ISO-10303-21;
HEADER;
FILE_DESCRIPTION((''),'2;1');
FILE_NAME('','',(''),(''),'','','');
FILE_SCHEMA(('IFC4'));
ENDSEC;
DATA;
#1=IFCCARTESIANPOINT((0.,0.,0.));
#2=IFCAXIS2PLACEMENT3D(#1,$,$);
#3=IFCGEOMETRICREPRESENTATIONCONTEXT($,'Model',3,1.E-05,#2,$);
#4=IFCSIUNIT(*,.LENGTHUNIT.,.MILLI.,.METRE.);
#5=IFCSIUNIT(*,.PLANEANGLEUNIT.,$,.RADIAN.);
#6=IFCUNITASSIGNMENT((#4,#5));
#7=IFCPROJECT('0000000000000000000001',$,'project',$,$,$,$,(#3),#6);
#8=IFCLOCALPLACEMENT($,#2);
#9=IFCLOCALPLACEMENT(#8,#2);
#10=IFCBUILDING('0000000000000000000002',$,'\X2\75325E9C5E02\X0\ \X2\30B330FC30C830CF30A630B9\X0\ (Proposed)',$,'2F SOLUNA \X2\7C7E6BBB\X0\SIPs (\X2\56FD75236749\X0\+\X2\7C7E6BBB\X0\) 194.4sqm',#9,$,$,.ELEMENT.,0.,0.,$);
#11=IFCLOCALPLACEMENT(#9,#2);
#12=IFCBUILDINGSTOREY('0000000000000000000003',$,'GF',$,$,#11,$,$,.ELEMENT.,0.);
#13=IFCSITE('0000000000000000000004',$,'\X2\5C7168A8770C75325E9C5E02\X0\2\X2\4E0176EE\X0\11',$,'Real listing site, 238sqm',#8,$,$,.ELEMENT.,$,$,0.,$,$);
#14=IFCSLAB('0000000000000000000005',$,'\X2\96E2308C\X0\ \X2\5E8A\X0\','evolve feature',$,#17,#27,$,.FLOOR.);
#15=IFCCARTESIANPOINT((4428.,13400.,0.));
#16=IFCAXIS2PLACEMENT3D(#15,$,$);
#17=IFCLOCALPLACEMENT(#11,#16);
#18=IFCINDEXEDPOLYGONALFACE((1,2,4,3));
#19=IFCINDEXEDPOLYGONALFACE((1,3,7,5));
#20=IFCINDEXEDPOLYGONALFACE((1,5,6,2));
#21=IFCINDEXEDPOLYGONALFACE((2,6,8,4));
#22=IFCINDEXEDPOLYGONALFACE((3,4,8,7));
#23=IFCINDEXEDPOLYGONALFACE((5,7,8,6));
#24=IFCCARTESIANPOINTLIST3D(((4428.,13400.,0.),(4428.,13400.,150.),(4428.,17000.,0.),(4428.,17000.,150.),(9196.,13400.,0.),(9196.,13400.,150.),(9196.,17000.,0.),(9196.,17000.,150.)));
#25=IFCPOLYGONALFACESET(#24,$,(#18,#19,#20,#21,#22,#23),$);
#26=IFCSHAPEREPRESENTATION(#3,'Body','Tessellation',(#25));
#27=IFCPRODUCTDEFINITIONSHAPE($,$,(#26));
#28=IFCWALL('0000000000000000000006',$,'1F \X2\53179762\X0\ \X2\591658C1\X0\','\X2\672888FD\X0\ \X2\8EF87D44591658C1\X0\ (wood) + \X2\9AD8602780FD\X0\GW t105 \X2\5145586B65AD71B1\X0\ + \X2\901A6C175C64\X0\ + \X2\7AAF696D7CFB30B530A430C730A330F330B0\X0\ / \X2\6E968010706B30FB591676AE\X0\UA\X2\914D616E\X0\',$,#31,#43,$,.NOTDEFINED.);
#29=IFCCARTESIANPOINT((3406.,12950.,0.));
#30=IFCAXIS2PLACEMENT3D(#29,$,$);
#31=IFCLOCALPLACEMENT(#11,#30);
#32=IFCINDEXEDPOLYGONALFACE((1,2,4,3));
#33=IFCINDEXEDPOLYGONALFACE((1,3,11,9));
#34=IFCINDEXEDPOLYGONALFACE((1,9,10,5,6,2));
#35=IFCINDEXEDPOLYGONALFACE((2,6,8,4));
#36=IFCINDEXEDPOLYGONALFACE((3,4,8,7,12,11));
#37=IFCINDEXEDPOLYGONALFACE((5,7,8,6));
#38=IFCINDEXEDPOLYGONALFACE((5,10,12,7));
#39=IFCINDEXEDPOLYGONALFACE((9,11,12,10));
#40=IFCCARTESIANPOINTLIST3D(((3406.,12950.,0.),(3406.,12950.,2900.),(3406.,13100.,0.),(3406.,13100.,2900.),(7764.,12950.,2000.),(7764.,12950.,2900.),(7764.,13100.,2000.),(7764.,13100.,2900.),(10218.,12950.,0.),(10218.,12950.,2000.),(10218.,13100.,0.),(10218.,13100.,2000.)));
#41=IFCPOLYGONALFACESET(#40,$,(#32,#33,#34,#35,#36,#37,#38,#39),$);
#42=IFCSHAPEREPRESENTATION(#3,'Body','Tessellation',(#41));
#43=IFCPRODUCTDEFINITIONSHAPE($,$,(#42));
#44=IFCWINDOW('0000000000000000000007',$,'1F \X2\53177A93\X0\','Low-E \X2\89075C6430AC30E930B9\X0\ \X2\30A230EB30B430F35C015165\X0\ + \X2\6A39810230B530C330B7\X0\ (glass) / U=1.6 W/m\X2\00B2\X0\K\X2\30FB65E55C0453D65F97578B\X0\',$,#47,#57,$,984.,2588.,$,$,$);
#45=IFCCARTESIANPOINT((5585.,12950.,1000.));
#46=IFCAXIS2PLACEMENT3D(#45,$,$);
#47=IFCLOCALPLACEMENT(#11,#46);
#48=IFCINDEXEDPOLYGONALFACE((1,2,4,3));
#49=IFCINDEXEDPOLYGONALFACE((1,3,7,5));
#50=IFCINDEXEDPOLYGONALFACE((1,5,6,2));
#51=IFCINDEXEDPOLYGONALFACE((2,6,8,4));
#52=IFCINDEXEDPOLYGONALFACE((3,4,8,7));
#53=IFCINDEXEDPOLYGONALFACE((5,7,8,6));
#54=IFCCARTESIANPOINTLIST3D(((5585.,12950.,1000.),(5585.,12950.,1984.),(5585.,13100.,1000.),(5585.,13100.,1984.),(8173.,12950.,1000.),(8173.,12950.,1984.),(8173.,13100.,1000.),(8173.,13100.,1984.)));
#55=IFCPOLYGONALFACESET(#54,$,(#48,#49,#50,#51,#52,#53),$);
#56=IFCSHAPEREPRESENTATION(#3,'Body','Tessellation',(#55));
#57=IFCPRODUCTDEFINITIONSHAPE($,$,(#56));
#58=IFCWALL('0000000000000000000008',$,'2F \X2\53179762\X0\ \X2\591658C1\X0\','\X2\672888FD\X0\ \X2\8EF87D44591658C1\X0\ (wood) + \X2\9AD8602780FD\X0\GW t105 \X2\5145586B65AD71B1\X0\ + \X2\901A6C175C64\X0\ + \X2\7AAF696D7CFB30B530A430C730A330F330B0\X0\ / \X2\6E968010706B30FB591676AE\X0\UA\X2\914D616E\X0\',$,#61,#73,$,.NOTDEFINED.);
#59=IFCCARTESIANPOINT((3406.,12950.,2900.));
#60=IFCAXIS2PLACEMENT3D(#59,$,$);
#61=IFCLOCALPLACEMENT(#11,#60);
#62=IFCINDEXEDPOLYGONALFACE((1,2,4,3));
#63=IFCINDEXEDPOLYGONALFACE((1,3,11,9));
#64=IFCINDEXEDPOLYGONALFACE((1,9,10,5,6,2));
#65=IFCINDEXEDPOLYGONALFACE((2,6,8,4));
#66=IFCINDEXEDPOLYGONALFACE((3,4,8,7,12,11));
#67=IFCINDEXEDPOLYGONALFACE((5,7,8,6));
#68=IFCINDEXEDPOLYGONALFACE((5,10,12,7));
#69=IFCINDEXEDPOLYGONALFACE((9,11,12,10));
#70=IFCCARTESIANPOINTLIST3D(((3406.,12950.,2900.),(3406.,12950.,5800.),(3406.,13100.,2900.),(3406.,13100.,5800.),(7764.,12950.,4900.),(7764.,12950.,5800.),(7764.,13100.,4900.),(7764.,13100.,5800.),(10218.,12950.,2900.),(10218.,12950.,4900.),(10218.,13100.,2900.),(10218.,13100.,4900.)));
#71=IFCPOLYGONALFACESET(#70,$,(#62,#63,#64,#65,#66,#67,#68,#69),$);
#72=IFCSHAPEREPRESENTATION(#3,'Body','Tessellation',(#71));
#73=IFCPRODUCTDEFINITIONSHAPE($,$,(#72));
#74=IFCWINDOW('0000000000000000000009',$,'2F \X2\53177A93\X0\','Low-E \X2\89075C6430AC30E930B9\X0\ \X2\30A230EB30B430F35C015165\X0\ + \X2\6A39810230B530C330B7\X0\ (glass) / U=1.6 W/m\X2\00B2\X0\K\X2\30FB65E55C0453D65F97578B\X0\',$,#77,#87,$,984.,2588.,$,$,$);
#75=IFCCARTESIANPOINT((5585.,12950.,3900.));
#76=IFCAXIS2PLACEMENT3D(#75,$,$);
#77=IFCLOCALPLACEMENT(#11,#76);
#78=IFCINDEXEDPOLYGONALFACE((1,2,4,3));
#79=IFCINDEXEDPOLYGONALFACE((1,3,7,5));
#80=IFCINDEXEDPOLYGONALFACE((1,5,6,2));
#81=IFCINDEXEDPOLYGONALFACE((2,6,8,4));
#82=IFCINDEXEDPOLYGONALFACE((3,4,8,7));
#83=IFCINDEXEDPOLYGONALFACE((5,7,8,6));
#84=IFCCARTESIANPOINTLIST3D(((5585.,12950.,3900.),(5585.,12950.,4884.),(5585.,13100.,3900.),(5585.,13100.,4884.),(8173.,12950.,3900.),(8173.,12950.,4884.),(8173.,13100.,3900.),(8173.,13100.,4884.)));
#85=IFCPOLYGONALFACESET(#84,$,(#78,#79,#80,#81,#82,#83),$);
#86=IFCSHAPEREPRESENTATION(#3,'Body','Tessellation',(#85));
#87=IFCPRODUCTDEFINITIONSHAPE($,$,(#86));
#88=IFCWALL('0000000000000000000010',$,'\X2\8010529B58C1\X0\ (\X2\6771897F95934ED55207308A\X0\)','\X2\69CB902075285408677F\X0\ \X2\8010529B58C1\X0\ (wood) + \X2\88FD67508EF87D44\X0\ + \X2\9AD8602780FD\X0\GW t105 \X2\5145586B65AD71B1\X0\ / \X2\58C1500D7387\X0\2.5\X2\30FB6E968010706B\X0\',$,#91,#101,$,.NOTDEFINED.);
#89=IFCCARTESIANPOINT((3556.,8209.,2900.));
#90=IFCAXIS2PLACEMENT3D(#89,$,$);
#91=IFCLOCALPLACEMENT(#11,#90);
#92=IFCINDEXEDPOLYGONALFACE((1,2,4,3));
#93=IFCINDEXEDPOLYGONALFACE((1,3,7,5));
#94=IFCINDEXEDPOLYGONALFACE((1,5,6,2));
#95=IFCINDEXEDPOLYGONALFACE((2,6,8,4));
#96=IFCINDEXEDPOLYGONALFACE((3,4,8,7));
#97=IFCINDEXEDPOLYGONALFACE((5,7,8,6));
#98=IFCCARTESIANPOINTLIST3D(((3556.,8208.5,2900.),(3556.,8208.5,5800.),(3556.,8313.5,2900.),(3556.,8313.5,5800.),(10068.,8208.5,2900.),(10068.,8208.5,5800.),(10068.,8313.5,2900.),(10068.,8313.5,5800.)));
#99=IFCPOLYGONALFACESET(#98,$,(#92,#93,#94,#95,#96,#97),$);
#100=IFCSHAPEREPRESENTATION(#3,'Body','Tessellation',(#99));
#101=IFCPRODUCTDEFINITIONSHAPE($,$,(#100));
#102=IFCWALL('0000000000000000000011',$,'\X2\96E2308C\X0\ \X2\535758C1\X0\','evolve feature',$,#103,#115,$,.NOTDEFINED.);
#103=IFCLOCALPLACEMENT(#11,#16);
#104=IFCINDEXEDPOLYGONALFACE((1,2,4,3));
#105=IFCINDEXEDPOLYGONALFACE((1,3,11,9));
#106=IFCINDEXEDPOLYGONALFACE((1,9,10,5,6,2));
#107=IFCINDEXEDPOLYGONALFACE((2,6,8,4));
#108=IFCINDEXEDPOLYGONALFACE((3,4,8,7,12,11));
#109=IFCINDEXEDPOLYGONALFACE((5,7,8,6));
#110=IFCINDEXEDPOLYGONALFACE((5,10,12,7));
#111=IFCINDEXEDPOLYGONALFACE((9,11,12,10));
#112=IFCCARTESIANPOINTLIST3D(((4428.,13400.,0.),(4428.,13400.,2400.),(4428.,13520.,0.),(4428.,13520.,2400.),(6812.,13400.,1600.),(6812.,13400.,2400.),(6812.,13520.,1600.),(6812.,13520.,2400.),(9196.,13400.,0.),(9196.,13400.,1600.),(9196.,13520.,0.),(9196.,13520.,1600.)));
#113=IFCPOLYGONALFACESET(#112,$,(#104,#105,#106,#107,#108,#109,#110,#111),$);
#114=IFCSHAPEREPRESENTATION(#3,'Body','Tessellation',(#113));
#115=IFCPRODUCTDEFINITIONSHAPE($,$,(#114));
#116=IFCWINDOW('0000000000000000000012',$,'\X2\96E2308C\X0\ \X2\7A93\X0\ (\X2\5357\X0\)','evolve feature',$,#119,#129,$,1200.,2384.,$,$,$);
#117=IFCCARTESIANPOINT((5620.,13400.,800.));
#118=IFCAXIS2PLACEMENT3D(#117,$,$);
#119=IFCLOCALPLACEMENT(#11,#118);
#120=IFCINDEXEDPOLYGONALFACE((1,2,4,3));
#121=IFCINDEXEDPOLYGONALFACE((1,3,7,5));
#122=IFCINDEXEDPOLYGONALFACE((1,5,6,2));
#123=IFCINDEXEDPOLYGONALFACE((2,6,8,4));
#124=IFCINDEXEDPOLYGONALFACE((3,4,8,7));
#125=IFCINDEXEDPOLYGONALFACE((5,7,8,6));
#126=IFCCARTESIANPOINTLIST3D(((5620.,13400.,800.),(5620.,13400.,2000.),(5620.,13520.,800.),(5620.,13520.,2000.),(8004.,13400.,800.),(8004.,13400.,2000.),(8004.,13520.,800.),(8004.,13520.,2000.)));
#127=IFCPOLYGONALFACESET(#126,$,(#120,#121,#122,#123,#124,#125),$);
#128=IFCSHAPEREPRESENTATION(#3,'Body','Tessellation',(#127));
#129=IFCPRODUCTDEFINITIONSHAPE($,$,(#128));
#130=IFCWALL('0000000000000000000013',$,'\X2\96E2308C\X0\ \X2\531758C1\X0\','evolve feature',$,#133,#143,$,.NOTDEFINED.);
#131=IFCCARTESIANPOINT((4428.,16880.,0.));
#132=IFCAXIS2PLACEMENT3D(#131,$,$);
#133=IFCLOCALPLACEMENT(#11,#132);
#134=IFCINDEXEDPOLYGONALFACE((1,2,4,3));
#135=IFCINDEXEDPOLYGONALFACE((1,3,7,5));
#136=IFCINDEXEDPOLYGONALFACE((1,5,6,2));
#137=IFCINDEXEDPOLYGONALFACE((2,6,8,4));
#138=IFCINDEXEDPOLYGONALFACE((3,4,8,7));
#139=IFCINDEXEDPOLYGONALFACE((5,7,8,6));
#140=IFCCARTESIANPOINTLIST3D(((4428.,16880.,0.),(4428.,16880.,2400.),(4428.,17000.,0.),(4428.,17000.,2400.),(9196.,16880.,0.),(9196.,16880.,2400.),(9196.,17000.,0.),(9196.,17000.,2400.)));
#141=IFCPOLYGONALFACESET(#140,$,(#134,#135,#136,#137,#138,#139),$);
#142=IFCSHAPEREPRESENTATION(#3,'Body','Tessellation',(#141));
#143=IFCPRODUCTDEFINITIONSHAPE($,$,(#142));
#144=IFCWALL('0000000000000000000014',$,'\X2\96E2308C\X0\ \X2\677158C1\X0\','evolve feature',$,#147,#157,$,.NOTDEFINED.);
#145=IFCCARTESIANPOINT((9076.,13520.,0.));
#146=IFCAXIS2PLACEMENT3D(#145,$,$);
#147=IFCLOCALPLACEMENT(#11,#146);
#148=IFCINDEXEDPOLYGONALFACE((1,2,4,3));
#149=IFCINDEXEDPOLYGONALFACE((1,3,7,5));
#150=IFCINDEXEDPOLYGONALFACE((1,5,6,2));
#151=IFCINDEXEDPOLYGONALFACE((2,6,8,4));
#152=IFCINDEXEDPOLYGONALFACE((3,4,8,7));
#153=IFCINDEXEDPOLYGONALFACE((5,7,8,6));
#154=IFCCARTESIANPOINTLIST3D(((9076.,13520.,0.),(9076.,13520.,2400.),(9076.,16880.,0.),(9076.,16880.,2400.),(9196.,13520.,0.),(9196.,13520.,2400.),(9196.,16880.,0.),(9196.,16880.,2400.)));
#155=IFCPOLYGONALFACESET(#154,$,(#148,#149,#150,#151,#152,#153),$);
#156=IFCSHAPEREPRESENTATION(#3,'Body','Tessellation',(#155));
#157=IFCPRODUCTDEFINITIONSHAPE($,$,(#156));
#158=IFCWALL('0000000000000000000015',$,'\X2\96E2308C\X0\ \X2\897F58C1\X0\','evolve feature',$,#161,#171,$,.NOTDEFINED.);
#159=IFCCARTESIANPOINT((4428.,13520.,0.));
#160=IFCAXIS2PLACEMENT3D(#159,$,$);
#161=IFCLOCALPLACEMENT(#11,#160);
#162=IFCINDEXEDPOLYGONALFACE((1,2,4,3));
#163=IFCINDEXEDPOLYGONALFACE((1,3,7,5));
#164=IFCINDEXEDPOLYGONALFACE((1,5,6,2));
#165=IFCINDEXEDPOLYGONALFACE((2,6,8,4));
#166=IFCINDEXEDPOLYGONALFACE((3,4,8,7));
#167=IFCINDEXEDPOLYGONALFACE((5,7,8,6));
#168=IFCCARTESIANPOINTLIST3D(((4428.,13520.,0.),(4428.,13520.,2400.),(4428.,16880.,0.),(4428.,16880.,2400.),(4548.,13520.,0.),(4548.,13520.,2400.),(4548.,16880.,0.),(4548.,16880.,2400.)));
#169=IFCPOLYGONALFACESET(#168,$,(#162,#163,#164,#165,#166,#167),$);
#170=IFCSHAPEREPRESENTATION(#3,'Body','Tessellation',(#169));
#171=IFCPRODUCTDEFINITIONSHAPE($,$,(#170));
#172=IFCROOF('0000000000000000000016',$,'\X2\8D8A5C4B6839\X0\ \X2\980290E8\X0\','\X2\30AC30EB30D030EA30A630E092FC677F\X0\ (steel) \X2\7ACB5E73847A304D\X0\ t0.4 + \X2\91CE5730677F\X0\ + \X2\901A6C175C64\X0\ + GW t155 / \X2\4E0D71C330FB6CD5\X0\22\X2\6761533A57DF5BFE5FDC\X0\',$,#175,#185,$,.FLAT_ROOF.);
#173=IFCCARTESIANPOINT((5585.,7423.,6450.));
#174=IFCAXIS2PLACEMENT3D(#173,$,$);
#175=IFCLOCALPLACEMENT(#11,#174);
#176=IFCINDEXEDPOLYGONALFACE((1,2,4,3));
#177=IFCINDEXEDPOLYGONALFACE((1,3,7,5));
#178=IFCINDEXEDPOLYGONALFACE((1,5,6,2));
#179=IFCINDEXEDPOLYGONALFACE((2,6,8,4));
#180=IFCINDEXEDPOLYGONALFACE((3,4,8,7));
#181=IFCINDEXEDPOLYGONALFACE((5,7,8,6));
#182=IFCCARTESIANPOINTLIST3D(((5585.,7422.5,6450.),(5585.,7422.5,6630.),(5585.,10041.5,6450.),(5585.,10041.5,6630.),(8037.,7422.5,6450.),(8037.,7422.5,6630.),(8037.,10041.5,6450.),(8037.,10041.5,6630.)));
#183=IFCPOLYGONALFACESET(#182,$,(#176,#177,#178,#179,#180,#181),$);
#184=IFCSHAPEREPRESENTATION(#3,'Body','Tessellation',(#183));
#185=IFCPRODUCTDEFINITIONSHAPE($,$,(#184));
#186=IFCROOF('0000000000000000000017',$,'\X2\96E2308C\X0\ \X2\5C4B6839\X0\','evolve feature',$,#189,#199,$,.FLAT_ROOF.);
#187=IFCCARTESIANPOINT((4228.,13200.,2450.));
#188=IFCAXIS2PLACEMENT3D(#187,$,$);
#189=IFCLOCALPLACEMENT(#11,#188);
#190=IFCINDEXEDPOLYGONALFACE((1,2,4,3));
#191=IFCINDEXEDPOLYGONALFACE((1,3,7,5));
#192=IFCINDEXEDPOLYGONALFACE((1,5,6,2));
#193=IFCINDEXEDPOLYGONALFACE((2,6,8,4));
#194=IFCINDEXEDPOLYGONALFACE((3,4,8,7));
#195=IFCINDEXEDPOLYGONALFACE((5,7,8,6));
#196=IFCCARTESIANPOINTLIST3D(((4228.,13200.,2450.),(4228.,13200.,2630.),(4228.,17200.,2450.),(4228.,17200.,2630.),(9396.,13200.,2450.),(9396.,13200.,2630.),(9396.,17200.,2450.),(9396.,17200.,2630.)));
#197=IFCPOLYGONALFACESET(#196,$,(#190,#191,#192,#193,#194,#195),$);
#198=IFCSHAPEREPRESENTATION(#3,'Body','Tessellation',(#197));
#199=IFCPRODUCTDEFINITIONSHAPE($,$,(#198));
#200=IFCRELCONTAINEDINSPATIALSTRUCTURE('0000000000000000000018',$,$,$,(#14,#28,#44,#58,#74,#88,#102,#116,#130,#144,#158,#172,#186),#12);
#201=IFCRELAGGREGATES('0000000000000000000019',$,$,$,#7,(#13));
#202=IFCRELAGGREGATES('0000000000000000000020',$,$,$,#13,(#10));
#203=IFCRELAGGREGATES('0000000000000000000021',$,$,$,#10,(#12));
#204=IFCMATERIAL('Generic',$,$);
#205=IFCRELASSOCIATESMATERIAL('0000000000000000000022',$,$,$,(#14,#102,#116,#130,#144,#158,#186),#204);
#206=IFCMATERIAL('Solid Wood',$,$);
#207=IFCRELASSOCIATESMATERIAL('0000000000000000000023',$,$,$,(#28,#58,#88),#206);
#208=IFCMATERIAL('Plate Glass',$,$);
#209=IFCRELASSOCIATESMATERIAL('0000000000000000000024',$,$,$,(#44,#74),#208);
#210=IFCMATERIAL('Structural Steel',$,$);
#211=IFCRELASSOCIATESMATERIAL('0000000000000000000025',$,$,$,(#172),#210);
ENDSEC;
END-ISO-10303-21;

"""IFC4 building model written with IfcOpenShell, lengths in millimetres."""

from ifc_helpers import new_model, si_unit, frame, frame_2d, origin, place, context, project, spatial, rectangle, extrude, material, element, fill, save


model = new_model("IFC4")

# Units and contexts
model_context = context("Model", 3, precision=1e-05, world=origin())
ifc_project = project(units=[si_unit("LENGTHUNIT", "METRE", prefix="MILLI"), si_unit("PLANEANGLEUNIT", "RADIAN")], contexts=[model_context])

# Site, building, storey
site_placement = place(None, origin())
site = spatial("IfcSite", under=ifc_project, at=site_placement, Name="山梨県甲府市2丁目11", ObjectType="Real listing site, 238sqm", CompositionType="ELEMENT", RefElevation=0.0)
building_placement = place(site_placement, origin())
building = spatial("IfcBuilding", under=site, at=building_placement, Name="甲府市 コートハウス (Proposed)", ObjectType="2F SOLUNA 籾殻SIPs (国産杉+籾殻) 194.4sqm", CompositionType="ELEMENT", ElevationOfRefHeight=0.0, ElevationOfTerrain=0.0)
storey_placement = place(building_placement, origin())
storey = spatial("IfcBuildingStorey", under=building, at=storey_placement, Name="GF", CompositionType="ELEMENT", Elevation=0.0)

# Slab
ifc_material_1 = material(Name="Generic")
slab_placement = place(storey_placement, frame((4428.0, 13400.0, 0.0)))
element("IfcSlab", 1, at=slab_placement, inside=storey, material=ifc_material_1, Name="離れ 床", Description="evolve feature", PredefinedType="FLOOR", context=model_context, shape_type="SweptSolid", body=[
    extrude(rectangle(XDim=4768.0, YDim=3600.0, at=frame_2d((2384.0, 1800.0))), frame((4428.0, 13400.0, 0.0)), (0.0, 0.0, 1.0), 150.0),
])

# Wall, opening, window
ifc_material_2 = material(Name="Solid Wood")
wall_1_placement = place(storey_placement, frame((3406.0, 12950.0, 0.0)))
wall_1 = element("IfcWall", 2, at=wall_1_placement, inside=storey, material=ifc_material_2, Name="1F 北面 外壁", Description="木製 軸組外壁 (wood) + 高性能GW t105 充填断熱 + 通気層 + 窯業系サイディング / 準耐火・外皮UA配慮", PredefinedType="NOTDEFINED", context=model_context, shape_type="SweptSolid", body=[
    extrude(rectangle(XDim=6812.0, YDim=150.0, at=frame_2d((3406.0, 75.0))), frame((3406.0, 12950.0, 0.0)), (0.0, 0.0, 1.0), 2900.0),
])
opening_1_placement = place(storey_placement, frame((5585.0, 12950.0, 1000.0)))
opening_1 = element("IfcOpeningElement", 3, at=opening_1_placement, cuts=wall_1, PredefinedType="NOTDEFINED", context=model_context, shape_type="SweptSolid", body=[
    extrude(rectangle(XDim=2588.0, YDim=150.0, at=frame_2d((1294.0, 75.0))), frame((5585.0, 12950.0, 1000.0)), (0.0, 0.0, 1.0), 984.0),
])
ifc_material_3 = material(Name="Plate Glass")
window_1_placement = place(storey_placement, frame((5585.0, 12950.0, 1000.0)))
window_1 = element("IfcWindow", 4, at=window_1_placement, inside=storey, material=ifc_material_3, Name="1F 北窓", Description="Low-E 複層ガラス アルゴン封入 + 樹脂サッシ (glass) / U=1.6 W/m²K・日射取得型", OverallHeight=984.0, OverallWidth=2588.0, context=model_context, shape_type="SweptSolid", body=[
    extrude(rectangle(XDim=2588.0, YDim=150.0, at=frame_2d((1294.0, 75.0))), frame((5585.0, 12950.0, 1000.0)), (0.0, 0.0, 1.0), 984.0),
])
fill(opening_1, window_1)

# Wall, opening, window
wall_2_placement = place(storey_placement, frame((3406.0, 12950.0, 2900.0)))
wall_2 = element("IfcWall", 5, at=wall_2_placement, inside=storey, material=ifc_material_2, Name="2F 北面 外壁", Description="木製 軸組外壁 (wood) + 高性能GW t105 充填断熱 + 通気層 + 窯業系サイディング / 準耐火・外皮UA配慮", PredefinedType="NOTDEFINED", context=model_context, shape_type="SweptSolid", body=[
    extrude(rectangle(XDim=6812.0, YDim=150.0, at=frame_2d((3406.0, 75.0))), frame((3406.0, 12950.0, 2900.0)), (0.0, 0.0, 1.0), 2900.0),
])
opening_2_placement = place(storey_placement, frame((5585.0, 12950.0, 3900.0)))
opening_2 = element("IfcOpeningElement", 6, at=opening_2_placement, cuts=wall_2, PredefinedType="NOTDEFINED", context=model_context, shape_type="SweptSolid", body=[
    extrude(rectangle(XDim=2588.0, YDim=150.0, at=frame_2d((1294.0, 75.0))), frame((5585.0, 12950.0, 3900.0)), (0.0, 0.0, 1.0), 984.0),
])
window_2_placement = place(storey_placement, frame((5585.0, 12950.0, 3900.0)))
window_2 = element("IfcWindow", 7, at=window_2_placement, inside=storey, material=ifc_material_3, Name="2F 北窓", Description="Low-E 複層ガラス アルゴン封入 + 樹脂サッシ (glass) / U=1.6 W/m²K・日射取得型", OverallHeight=984.0, OverallWidth=2588.0, context=model_context, shape_type="SweptSolid", body=[
    extrude(rectangle(XDim=2588.0, YDim=150.0, at=frame_2d((1294.0, 75.0))), frame((5585.0, 12950.0, 3900.0)), (0.0, 0.0, 1.0), 984.0),
])
fill(opening_2, window_2)

# Wall
wall_3_placement = place(storey_placement, frame((3556.0, 8209.0, 2900.0)))
element("IfcWall", 8, at=wall_3_placement, inside=storey, material=ifc_material_2, Name="耐力壁 (東西間仕切り)", Description="構造用合板 耐力壁 (wood) + 製材軸組 + 高性能GW t105 充填断熱 / 壁倍率2.5・準耐火", PredefinedType="NOTDEFINED", context=model_context, shape_type="SweptSolid", body=[
    extrude(rectangle(XDim=6512.0, YDim=105.0, at=frame_2d((3256.0, 52.0))), frame((3556.0, 8209.0, 2900.0)), (0.0, 0.0, 1.0), 2900.0),
])

# Wall, opening, window
wall_4_placement = place(storey_placement, frame((4428.0, 13400.0, 0.0)))
wall_4 = element("IfcWall", 9, at=wall_4_placement, inside=storey, material=ifc_material_1, Name="離れ 南壁", Description="evolve feature", PredefinedType="NOTDEFINED", context=model_context, shape_type="SweptSolid", body=[
    extrude(rectangle(XDim=4768.0, YDim=120.0, at=frame_2d((2384.0, 60.0))), frame((4428.0, 13400.0, 0.0)), (0.0, 0.0, 1.0), 2400.0),
])
opening_3_placement = place(storey_placement, frame((5620.0, 13400.0, 800.0)))
opening_3 = element("IfcOpeningElement", 10, at=opening_3_placement, cuts=wall_4, PredefinedType="NOTDEFINED", context=model_context, shape_type="SweptSolid", body=[
    extrude(rectangle(XDim=2384.0, YDim=120.0, at=frame_2d((1192.0, 60.0))), frame((5620.0, 13400.0, 800.0)), (0.0, 0.0, 1.0), 1200.0),
])
window_3_placement = place(storey_placement, frame((5620.0, 13400.0, 800.0)))
window_3 = element("IfcWindow", 11, at=window_3_placement, inside=storey, material=ifc_material_1, Name="離れ 窓 (南)", Description="evolve feature", OverallHeight=1200.0, OverallWidth=2384.0, context=model_context, shape_type="SweptSolid", body=[
    extrude(rectangle(XDim=2384.0, YDim=120.0, at=frame_2d((1192.0, 60.0))), frame((5620.0, 13400.0, 800.0)), (0.0, 0.0, 1.0), 1200.0),
])
fill(opening_3, window_3)

# Walls
wall_5_placement = place(storey_placement, frame((4428.0, 16880.0, 0.0)))
element("IfcWall", 12, at=wall_5_placement, inside=storey, material=ifc_material_1, Name="離れ 北壁", Description="evolve feature", PredefinedType="NOTDEFINED", context=model_context, shape_type="SweptSolid", body=[
    extrude(rectangle(XDim=4768.0, YDim=120.0, at=frame_2d((2384.0, 60.0))), frame((4428.0, 16880.0, 0.0)), (0.0, 0.0, 1.0), 2400.0),
])
wall_6_placement = place(storey_placement, frame((9076.0, 13520.0, 0.0)))
element("IfcWall", 13, at=wall_6_placement, inside=storey, material=ifc_material_1, Name="離れ 東壁", Description="evolve feature", PredefinedType="NOTDEFINED", context=model_context, shape_type="SweptSolid", body=[
    extrude(rectangle(XDim=120.0, YDim=3360.0, at=frame_2d((60.0, 1680.0))), frame((9076.0, 13520.0, 0.0)), (0.0, 0.0, 1.0), 2400.0),
])
wall_7_placement = place(storey_placement, frame((4428.0, 13520.0, 0.0)))
element("IfcWall", 14, at=wall_7_placement, inside=storey, material=ifc_material_1, Name="離れ 西壁", Description="evolve feature", PredefinedType="NOTDEFINED", context=model_context, shape_type="SweptSolid", body=[
    extrude(rectangle(XDim=120.0, YDim=3360.0, at=frame_2d((60.0, 1680.0))), frame((4428.0, 13520.0, 0.0)), (0.0, 0.0, 1.0), 2400.0),
])

# Roofs
ifc_material_4 = material(Name="Structural Steel")
roof_1_placement = place(storey_placement, frame((5585.0, 7423.0, 6450.0)))
element("IfcRoof", 15, at=roof_1_placement, inside=storey, material=ifc_material_4, Name="越屋根 頂部", Description="ガルバリウム鋼板 (steel) 立平葺き t0.4 + 野地板 + 通気層 + GW t155 / 不燃・法22条区域対応", PredefinedType="FLAT_ROOF", context=model_context, shape_type="SweptSolid", body=[
    extrude(rectangle(XDim=2452.0, YDim=2619.0, at=frame_2d((1226.0, 1309.0))), frame((5585.0, 7423.0, 6450.0)), (0.0, 0.0, 1.0), 180.0),
])
roof_2_placement = place(storey_placement, frame((4228.0, 13200.0, 2450.0)))
element("IfcRoof", 16, at=roof_2_placement, inside=storey, material=ifc_material_1, Name="離れ 屋根", Description="evolve feature", PredefinedType="FLAT_ROOF", context=model_context, shape_type="SweptSolid", body=[
    extrude(rectangle(XDim=5168.0, YDim=4000.0, at=frame_2d((2584.0, 2000.0))), frame((4228.0, 13200.0, 2450.0)), (0.0, 0.0, 1.0), 180.0),
])

save(model, "model.ifc")
